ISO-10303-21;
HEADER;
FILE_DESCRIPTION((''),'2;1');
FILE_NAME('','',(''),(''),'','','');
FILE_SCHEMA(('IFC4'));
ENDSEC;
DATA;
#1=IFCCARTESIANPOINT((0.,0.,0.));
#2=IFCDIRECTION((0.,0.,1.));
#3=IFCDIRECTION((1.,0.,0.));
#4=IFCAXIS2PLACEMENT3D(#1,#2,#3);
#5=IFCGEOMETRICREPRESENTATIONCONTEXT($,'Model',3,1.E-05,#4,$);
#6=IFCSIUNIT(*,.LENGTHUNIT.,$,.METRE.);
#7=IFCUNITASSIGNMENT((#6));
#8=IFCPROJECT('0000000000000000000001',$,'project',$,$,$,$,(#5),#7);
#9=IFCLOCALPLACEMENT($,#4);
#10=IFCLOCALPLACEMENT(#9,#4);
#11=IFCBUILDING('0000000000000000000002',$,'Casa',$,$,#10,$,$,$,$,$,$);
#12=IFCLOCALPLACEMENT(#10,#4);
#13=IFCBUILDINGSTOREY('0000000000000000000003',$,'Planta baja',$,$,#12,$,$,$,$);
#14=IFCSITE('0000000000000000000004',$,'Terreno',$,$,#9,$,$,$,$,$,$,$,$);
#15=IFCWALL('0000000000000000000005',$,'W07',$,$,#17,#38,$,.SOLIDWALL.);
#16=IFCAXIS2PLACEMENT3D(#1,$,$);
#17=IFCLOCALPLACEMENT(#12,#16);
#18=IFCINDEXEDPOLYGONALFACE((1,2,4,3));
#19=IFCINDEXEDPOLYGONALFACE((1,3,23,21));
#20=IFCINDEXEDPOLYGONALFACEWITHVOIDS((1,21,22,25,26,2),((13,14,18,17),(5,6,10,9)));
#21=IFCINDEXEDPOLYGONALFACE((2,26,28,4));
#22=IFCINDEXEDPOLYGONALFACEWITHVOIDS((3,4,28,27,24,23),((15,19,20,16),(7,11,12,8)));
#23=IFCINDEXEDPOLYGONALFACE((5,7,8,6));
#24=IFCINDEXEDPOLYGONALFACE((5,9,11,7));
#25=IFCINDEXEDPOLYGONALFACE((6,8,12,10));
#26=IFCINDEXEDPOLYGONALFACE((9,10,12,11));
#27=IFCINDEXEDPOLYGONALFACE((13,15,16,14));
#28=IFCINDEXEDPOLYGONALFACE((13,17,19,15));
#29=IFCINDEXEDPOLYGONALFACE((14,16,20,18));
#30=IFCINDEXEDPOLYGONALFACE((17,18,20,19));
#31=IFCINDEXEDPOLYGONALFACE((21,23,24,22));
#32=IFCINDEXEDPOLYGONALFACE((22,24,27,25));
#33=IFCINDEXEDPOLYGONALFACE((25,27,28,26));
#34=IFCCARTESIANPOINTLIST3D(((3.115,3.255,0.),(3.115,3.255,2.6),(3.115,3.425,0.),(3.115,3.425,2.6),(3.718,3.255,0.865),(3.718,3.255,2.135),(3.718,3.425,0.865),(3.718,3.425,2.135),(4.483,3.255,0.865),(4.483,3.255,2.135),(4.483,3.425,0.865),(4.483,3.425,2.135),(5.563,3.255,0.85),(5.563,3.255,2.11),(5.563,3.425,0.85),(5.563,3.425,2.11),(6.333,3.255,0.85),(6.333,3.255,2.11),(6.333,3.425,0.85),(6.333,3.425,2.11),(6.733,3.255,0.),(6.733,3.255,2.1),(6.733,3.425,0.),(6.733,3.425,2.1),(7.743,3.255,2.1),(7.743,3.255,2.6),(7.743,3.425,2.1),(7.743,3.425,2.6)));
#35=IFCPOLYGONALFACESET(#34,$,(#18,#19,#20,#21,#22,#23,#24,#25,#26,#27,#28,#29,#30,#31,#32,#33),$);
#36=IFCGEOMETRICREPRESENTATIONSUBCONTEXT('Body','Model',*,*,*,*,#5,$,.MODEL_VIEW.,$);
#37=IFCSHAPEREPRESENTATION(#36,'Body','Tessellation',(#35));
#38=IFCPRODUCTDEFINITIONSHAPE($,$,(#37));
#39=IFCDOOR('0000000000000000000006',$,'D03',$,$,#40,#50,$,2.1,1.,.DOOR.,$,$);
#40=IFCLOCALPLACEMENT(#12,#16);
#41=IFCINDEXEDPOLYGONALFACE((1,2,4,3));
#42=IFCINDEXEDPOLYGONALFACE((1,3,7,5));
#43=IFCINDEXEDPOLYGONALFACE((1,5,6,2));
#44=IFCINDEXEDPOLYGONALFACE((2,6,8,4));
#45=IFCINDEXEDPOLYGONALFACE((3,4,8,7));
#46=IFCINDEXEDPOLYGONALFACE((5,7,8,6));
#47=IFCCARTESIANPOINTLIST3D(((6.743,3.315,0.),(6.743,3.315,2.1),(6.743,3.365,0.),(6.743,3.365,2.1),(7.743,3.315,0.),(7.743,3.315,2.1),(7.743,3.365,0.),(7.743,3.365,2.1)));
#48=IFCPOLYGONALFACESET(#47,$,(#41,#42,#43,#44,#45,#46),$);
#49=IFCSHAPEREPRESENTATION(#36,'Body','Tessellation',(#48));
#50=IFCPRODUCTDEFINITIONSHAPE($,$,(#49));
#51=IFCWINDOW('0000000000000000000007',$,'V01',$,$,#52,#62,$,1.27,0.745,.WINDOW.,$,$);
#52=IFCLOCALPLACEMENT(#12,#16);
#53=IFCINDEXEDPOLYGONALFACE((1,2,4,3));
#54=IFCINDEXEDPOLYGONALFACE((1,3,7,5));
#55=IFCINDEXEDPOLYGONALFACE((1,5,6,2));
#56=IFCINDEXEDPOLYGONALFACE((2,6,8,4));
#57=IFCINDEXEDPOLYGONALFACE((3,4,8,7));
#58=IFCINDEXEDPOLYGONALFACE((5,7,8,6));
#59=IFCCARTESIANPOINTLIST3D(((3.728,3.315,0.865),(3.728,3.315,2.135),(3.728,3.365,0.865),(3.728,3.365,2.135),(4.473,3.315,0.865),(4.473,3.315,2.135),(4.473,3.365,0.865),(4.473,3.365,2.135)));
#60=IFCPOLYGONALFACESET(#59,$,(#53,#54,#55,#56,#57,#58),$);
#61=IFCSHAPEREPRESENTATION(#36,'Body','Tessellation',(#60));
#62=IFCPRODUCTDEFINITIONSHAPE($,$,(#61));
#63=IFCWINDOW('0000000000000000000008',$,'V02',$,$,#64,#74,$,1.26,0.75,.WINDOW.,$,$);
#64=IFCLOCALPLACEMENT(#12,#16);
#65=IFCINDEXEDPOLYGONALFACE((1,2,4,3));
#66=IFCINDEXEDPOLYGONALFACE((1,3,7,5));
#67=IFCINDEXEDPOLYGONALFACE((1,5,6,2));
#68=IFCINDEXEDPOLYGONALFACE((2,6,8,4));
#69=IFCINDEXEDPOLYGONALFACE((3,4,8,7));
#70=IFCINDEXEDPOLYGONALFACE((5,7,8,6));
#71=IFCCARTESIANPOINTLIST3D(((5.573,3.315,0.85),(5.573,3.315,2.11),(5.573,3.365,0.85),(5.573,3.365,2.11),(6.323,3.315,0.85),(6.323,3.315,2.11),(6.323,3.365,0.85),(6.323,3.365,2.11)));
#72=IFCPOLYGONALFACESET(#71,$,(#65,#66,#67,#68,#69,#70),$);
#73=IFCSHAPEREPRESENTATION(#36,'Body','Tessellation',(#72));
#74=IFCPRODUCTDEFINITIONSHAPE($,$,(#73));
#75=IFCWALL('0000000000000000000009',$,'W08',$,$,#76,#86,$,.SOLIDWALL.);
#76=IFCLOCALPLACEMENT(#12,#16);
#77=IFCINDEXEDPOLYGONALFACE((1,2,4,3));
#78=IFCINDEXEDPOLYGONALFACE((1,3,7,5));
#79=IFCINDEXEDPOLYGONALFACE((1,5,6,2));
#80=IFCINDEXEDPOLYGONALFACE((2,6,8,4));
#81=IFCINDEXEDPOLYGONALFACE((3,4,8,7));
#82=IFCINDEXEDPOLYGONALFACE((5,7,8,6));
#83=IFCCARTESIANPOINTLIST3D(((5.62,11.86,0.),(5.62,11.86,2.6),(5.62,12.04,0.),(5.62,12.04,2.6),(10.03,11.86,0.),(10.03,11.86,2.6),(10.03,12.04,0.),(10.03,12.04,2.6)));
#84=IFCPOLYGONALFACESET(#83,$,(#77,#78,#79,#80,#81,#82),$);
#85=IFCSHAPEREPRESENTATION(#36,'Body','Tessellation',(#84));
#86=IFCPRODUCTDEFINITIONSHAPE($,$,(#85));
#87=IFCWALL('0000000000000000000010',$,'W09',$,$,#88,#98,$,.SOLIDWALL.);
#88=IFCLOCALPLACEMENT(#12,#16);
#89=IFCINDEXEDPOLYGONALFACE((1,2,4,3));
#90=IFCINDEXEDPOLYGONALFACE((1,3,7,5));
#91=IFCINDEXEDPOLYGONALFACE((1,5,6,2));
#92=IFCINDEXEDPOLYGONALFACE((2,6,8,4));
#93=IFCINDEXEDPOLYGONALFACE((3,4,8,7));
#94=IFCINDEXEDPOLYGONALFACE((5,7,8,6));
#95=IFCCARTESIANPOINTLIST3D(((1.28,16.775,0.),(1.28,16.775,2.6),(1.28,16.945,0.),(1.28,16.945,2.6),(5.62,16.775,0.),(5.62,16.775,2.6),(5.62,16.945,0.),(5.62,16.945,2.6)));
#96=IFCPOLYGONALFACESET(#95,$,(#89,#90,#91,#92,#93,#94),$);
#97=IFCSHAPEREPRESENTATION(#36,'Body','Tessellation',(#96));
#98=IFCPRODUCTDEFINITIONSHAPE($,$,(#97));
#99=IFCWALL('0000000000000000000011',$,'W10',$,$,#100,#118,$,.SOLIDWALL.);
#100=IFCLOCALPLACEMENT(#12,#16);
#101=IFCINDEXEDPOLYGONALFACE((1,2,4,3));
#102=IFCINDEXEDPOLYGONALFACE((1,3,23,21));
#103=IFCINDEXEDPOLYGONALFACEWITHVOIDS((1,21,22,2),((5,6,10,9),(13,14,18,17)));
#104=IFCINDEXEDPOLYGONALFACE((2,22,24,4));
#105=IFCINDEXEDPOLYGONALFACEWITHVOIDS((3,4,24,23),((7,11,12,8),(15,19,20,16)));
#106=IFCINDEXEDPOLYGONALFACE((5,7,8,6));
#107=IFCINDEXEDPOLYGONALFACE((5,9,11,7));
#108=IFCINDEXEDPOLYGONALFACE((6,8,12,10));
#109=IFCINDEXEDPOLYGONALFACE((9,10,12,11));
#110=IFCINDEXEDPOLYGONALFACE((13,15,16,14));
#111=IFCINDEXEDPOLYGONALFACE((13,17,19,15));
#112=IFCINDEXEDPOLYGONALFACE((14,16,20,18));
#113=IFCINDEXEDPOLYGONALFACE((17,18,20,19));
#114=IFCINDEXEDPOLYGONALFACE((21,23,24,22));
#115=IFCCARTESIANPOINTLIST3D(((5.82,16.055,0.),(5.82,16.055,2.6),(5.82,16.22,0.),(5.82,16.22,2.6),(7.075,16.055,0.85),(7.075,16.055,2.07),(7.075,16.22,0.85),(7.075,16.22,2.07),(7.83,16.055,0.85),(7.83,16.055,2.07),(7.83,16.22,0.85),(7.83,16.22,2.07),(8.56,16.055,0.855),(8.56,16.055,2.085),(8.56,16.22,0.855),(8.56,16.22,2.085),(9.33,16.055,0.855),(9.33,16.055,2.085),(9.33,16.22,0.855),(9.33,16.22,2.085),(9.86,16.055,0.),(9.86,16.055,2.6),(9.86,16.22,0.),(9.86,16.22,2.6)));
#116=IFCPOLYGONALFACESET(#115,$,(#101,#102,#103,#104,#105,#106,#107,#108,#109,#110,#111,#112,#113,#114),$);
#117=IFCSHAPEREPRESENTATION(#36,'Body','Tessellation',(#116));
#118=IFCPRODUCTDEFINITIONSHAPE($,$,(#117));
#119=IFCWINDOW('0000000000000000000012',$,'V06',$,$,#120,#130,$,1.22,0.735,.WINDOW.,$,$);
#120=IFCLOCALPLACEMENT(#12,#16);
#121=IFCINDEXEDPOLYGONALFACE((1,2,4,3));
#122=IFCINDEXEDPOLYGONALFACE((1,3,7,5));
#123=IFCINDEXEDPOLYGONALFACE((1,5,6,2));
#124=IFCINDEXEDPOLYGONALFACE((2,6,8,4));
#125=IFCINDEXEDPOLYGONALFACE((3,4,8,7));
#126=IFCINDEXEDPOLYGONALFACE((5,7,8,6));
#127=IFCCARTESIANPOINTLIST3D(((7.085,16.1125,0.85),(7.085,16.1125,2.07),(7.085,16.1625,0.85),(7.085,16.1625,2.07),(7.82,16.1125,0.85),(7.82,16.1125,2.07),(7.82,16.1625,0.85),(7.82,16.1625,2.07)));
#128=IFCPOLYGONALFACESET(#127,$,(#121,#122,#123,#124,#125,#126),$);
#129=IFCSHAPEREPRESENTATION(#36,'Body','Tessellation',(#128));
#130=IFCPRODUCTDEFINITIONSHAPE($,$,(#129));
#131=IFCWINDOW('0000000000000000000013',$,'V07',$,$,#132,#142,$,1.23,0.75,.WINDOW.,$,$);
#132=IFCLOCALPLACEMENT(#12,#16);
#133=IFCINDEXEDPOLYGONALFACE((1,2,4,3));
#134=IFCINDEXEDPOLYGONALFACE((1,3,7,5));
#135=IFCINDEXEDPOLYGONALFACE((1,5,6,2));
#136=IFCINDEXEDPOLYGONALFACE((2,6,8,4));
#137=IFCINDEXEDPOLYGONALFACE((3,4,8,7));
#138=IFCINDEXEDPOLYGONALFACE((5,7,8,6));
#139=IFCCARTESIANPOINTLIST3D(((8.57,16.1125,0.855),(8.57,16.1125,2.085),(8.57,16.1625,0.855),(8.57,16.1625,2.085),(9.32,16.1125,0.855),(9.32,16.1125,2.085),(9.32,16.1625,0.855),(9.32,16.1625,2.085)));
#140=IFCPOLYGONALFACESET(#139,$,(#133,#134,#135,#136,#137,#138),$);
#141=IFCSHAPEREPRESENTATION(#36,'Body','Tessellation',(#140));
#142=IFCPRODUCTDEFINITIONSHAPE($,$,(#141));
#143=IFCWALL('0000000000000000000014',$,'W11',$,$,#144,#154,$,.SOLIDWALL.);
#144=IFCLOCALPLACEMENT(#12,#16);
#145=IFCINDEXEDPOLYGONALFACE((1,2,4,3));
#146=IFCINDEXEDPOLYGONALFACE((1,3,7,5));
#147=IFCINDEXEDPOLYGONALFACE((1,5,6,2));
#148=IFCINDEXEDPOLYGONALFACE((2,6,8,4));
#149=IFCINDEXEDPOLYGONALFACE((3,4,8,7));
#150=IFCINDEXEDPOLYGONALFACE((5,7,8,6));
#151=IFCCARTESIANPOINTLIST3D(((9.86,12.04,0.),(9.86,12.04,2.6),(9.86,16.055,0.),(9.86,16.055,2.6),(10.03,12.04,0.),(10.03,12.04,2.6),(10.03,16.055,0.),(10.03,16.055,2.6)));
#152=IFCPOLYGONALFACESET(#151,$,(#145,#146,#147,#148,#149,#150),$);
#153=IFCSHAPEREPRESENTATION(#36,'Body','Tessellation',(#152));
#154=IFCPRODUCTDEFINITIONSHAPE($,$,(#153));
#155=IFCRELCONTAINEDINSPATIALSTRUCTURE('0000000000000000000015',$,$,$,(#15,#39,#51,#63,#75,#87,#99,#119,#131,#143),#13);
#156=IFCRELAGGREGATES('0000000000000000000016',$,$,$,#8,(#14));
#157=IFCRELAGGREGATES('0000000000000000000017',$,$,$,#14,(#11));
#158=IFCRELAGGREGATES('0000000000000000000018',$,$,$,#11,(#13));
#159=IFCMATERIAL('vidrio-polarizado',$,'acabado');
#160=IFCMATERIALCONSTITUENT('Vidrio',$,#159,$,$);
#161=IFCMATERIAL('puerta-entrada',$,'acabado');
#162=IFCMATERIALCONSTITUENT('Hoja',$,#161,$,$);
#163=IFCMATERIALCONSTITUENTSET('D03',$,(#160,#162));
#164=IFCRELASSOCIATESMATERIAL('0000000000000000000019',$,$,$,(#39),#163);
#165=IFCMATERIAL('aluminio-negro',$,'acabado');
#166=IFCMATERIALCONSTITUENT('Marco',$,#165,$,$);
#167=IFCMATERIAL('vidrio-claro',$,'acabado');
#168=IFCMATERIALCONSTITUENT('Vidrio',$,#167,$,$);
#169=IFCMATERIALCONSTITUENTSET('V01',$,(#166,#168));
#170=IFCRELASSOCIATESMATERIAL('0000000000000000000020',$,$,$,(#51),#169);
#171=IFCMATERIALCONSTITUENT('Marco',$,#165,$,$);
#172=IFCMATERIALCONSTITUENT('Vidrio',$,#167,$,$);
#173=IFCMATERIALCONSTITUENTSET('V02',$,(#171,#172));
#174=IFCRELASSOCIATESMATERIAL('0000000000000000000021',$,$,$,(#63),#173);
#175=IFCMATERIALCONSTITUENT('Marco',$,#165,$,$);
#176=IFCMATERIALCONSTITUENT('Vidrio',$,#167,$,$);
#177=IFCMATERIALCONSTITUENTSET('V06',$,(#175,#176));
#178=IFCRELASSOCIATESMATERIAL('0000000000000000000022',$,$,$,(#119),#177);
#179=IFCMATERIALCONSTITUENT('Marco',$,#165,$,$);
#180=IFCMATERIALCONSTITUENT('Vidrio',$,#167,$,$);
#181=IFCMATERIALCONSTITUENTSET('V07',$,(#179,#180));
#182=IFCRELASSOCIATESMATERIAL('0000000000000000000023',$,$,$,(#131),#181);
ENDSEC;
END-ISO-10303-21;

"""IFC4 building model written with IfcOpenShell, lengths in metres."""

from ifc_helpers import new_model, si_unit, frame, origin_with_axes, place, context, subcontext, project, spatial, line, indexed_curve, outline, extrude, material, constituent, constituent_set, element, fill, save


model = new_model("IFC4")

# Units and contexts
model_context = context("Model", 3, precision=1e-05, world=origin_with_axes())
body_context = subcontext(model_context, "Body", "Model", "MODEL_VIEW")
ifc_project = project(units=[si_unit("LENGTHUNIT", "METRE")], contexts=[model_context])

# Site, building, storey
site_placement = place(None, origin_with_axes())
site = spatial("IfcSite", under=ifc_project, at=site_placement, Name="Terreno")
building_placement = place(site_placement, origin_with_axes())
building = spatial("IfcBuilding", under=site, at=building_placement, Name="Casa")
storey_placement = place(building_placement, origin_with_axes())
storey = spatial("IfcBuildingStorey", under=building, at=storey_placement, Name="Planta baja")

# Wall, openings, door, windows
wall_1_placement = place(storey_placement, origin_with_axes())
wall_1 = element("IfcWall", 1, at=wall_1_placement, inside=storey, Name="W07", PredefinedType="SOLIDWALL", context=body_context, shape_type="SweptSolid", body=[
    extrude(outline(indexed_curve([(3.115, 3.425), (7.743, 3.425), (7.743, 3.255), (3.115, 3.255)], segments=[line(1, 2, 3, 4, 1)])), origin_with_axes(), (0.0, 0.0, 1.0), 2.6),
])
opening_1_placement = place(wall_1_placement, origin_with_axes())
opening_1 = element("IfcOpeningElement", 2, at=opening_1_placement, cuts=wall_1, PredefinedType="OPENING", context=body_context, shape_type="SweptSolid", body=[
    extrude(outline(indexed_curve([(6.733, 3.245), (7.753, 3.245), (7.753, 3.435), (6.733, 3.435)], segments=[line(1, 2, 3, 4, 1)])), origin_with_axes(), (0.0, 0.0, 1.0), 2.1),
])
opening_2_placement = place(wall_1_placement, origin_with_axes())
opening_2 = element("IfcOpeningElement", 3, at=opening_2_placement, cuts=wall_1, PredefinedType="OPENING", context=body_context, shape_type="SweptSolid", body=[
    extrude(outline(indexed_curve([(3.718, 3.245), (4.483, 3.245), (4.483, 3.435), (3.718, 3.435)], segments=[line(1, 2, 3, 4, 1)])), frame((0.0, 0.0, 0.865), z_axis=(0.0, 0.0, 1.0), x_axis=(1.0, 0.0, 0.0)), (0.0, 0.0, 1.0), 1.27),
])
opening_3_placement = place(wall_1_placement, origin_with_axes())
opening_3 = element("IfcOpeningElement", 4, at=opening_3_placement, cuts=wall_1, PredefinedType="OPENING", context=body_context, shape_type="SweptSolid", body=[
    extrude(outline(indexed_curve([(5.563, 3.245), (6.333, 3.245), (6.333, 3.435), (5.563, 3.435)], segments=[line(1, 2, 3, 4, 1)])), frame((0.0, 0.0, 0.85), z_axis=(0.0, 0.0, 1.0), x_axis=(1.0, 0.0, 0.0)), (0.0, 0.0, 1.0), 1.26),
])
ifc_material_1 = material(Name="vidrio-polarizado", Category="acabado")
ifc_constituent_1 = constituent(ifc_material_1, Name="Vidrio")
ifc_material_2 = material(Name="puerta-entrada", Category="acabado")
ifc_constituent_2 = constituent(ifc_material_2, Name="Hoja")
ifc_constituent_set_1 = constituent_set(constituents=[ifc_constituent_1, ifc_constituent_2], Name="D03")
door_1_placement = place(opening_1_placement, origin_with_axes())
door_1 = element("IfcDoor", 5, at=door_1_placement, inside=storey, material=ifc_constituent_set_1, Name="D03", OverallHeight=2.1, OverallWidth=1.0, PredefinedType="DOOR", context=body_context, shape_type="SweptSolid", body=[
    extrude(outline(indexed_curve([(6.743, 3.315), (7.743, 3.315), (7.743, 3.365), (6.743, 3.365)], segments=[line(1, 2, 3, 4, 1)])), origin_with_axes(), (0.0, 0.0, 1.0), 2.1),
])
fill(opening_1, door_1)
ifc_material_3 = material(Name="aluminio-negro", Category="acabado")
ifc_constituent_3 = constituent(ifc_material_3, Name="Marco")
ifc_material_4 = material(Name="vidrio-claro", Category="acabado")
ifc_constituent_4 = constituent(ifc_material_4, Name="Vidrio")
ifc_constituent_set_2 = constituent_set(constituents=[ifc_constituent_3, ifc_constituent_4], Name="V01")
window_1_placement = place(opening_2_placement, origin_with_axes())
window_1 = element("IfcWindow", 6, at=window_1_placement, inside=storey, material=ifc_constituent_set_2, Name="V01", OverallHeight=1.27, OverallWidth=0.745, PredefinedType="WINDOW", context=body_context, shape_type="SweptSolid", body=[
    extrude(outline(indexed_curve([(3.728, 3.315), (4.473, 3.315), (4.473, 3.365), (3.728, 3.365)], segments=[line(1, 2, 3, 4, 1)])), frame((0.0, 0.0, 0.865), z_axis=(0.0, 0.0, 1.0), x_axis=(1.0, 0.0, 0.0)), (0.0, 0.0, 1.0), 1.27),
])
fill(opening_2, window_1)
ifc_constituent_5 = constituent(ifc_material_3, Name="Marco")
ifc_constituent_6 = constituent(ifc_material_4, Name="Vidrio")
ifc_constituent_set_3 = constituent_set(constituents=[ifc_constituent_5, ifc_constituent_6], Name="V02")
window_2_placement = place(opening_3_placement, origin_with_axes())
window_2 = element("IfcWindow", 7, at=window_2_placement, inside=storey, material=ifc_constituent_set_3, Name="V02", OverallHeight=1.26, OverallWidth=0.75, PredefinedType="WINDOW", context=body_context, shape_type="SweptSolid", body=[
    extrude(outline(indexed_curve([(5.573, 3.315), (6.323, 3.315), (6.323, 3.365), (5.573, 3.365)], segments=[line(1, 2, 3, 4, 1)])), frame((0.0, 0.0, 0.85), z_axis=(0.0, 0.0, 1.0), x_axis=(1.0, 0.0, 0.0)), (0.0, 0.0, 1.0), 1.26),
])
fill(opening_3, window_2)

# Walls
wall_2_placement = place(storey_placement, origin_with_axes())
element("IfcWall", 8, at=wall_2_placement, inside=storey, Name="W08", PredefinedType="SOLIDWALL", context=body_context, shape_type="SweptSolid", body=[
    extrude(outline(indexed_curve([(5.62, 11.86), (5.62, 12.04), (10.03, 12.04), (10.03, 11.86)], segments=[line(1, 2, 3, 4, 1)])), origin_with_axes(), (0.0, 0.0, 1.0), 2.6),
])
wall_3_placement = place(storey_placement, origin_with_axes())
element("IfcWall", 9, at=wall_3_placement, inside=storey, Name="W09", PredefinedType="SOLIDWALL", context=body_context, shape_type="SweptSolid", body=[
    extrude(outline(indexed_curve([(1.28, 16.775), (1.28, 16.945), (5.62, 16.945), (5.62, 16.775)], segments=[line(1, 2, 3, 4, 1)])), origin_with_axes(), (0.0, 0.0, 1.0), 2.6),
])

# Wall, openings, windows
wall_4_placement = place(storey_placement, origin_with_axes())
wall_4 = element("IfcWall", 10, at=wall_4_placement, inside=storey, Name="W10", PredefinedType="SOLIDWALL", context=body_context, shape_type="SweptSolid", body=[
    extrude(outline(indexed_curve([(5.82, 16.055), (5.82, 16.22), (9.86, 16.22), (9.86, 16.055)], segments=[line(1, 2, 3, 4, 1)])), origin_with_axes(), (0.0, 0.0, 1.0), 2.6),
])
opening_4_placement = place(wall_4_placement, origin_with_axes())
opening_4 = element("IfcOpeningElement", 11, at=opening_4_placement, cuts=wall_4, PredefinedType="OPENING", context=body_context, shape_type="SweptSolid", body=[
    extrude(outline(indexed_curve([(7.075, 16.045), (7.83, 16.045), (7.83, 16.23), (7.075, 16.23)], segments=[line(1, 2, 3, 4, 1)])), frame((0.0, 0.0, 0.85), z_axis=(0.0, 0.0, 1.0), x_axis=(1.0, 0.0, 0.0)), (0.0, 0.0, 1.0), 1.22),
])
opening_5_placement = place(wall_4_placement, origin_with_axes())
opening_5 = element("IfcOpeningElement", 12, at=opening_5_placement, cuts=wall_4, PredefinedType="OPENING", context=body_context, shape_type="SweptSolid", body=[
    extrude(outline(indexed_curve([(8.56, 16.045), (9.33, 16.045), (9.33, 16.23), (8.56, 16.23)], segments=[line(1, 2, 3, 4, 1)])), frame((0.0, 0.0, 0.855), z_axis=(0.0, 0.0, 1.0), x_axis=(1.0, 0.0, 0.0)), (0.0, 0.0, 1.0), 1.23),
])
ifc_constituent_7 = constituent(ifc_material_3, Name="Marco")
ifc_constituent_8 = constituent(ifc_material_4, Name="Vidrio")
ifc_constituent_set_4 = constituent_set(constituents=[ifc_constituent_7, ifc_constituent_8], Name="V06")
window_3_placement = place(opening_4_placement, origin_with_axes())
window_3 = element("IfcWindow", 13, at=window_3_placement, inside=storey, material=ifc_constituent_set_4, Name="V06", OverallHeight=1.22, OverallWidth=0.735, PredefinedType="WINDOW", context=body_context, shape_type="SweptSolid", body=[
    extrude(outline(indexed_curve([(7.085, 16.1125), (7.82, 16.1125), (7.82, 16.1625), (7.085, 16.1625)], segments=[line(1, 2, 3, 4, 1)])), frame((0.0, 0.0, 0.85), z_axis=(0.0, 0.0, 1.0), x_axis=(1.0, 0.0, 0.0)), (0.0, 0.0, 1.0), 1.22),
])
fill(opening_4, window_3)
ifc_constituent_9 = constituent(ifc_material_3, Name="Marco")
ifc_constituent_10 = constituent(ifc_material_4, Name="Vidrio")
ifc_constituent_set_5 = constituent_set(constituents=[ifc_constituent_9, ifc_constituent_10], Name="V07")
window_4_placement = place(opening_5_placement, origin_with_axes())
window_4 = element("IfcWindow", 14, at=window_4_placement, inside=storey, material=ifc_constituent_set_5, Name="V07", OverallHeight=1.23, OverallWidth=0.75, PredefinedType="WINDOW", context=body_context, shape_type="SweptSolid", body=[
    extrude(outline(indexed_curve([(8.57, 16.1125), (9.32, 16.1125), (9.32, 16.1625), (8.57, 16.1625)], segments=[line(1, 2, 3, 4, 1)])), frame((0.0, 0.0, 0.855), z_axis=(0.0, 0.0, 1.0), x_axis=(1.0, 0.0, 0.0)), (0.0, 0.0, 1.0), 1.23),
])
fill(opening_5, window_4)

# Wall
wall_5_placement = place(storey_placement, origin_with_axes())
element("IfcWall", 15, at=wall_5_placement, inside=storey, Name="W11", PredefinedType="SOLIDWALL", context=body_context, shape_type="SweptSolid", body=[
    extrude(outline(indexed_curve([(9.86, 12.04), (9.86, 16.055), (10.03, 16.055), (10.03, 12.04)], segments=[line(1, 2, 3, 4, 1)])), origin_with_axes(), (0.0, 0.0, 1.0), 2.6),
])

save(model, "model.ifc")
